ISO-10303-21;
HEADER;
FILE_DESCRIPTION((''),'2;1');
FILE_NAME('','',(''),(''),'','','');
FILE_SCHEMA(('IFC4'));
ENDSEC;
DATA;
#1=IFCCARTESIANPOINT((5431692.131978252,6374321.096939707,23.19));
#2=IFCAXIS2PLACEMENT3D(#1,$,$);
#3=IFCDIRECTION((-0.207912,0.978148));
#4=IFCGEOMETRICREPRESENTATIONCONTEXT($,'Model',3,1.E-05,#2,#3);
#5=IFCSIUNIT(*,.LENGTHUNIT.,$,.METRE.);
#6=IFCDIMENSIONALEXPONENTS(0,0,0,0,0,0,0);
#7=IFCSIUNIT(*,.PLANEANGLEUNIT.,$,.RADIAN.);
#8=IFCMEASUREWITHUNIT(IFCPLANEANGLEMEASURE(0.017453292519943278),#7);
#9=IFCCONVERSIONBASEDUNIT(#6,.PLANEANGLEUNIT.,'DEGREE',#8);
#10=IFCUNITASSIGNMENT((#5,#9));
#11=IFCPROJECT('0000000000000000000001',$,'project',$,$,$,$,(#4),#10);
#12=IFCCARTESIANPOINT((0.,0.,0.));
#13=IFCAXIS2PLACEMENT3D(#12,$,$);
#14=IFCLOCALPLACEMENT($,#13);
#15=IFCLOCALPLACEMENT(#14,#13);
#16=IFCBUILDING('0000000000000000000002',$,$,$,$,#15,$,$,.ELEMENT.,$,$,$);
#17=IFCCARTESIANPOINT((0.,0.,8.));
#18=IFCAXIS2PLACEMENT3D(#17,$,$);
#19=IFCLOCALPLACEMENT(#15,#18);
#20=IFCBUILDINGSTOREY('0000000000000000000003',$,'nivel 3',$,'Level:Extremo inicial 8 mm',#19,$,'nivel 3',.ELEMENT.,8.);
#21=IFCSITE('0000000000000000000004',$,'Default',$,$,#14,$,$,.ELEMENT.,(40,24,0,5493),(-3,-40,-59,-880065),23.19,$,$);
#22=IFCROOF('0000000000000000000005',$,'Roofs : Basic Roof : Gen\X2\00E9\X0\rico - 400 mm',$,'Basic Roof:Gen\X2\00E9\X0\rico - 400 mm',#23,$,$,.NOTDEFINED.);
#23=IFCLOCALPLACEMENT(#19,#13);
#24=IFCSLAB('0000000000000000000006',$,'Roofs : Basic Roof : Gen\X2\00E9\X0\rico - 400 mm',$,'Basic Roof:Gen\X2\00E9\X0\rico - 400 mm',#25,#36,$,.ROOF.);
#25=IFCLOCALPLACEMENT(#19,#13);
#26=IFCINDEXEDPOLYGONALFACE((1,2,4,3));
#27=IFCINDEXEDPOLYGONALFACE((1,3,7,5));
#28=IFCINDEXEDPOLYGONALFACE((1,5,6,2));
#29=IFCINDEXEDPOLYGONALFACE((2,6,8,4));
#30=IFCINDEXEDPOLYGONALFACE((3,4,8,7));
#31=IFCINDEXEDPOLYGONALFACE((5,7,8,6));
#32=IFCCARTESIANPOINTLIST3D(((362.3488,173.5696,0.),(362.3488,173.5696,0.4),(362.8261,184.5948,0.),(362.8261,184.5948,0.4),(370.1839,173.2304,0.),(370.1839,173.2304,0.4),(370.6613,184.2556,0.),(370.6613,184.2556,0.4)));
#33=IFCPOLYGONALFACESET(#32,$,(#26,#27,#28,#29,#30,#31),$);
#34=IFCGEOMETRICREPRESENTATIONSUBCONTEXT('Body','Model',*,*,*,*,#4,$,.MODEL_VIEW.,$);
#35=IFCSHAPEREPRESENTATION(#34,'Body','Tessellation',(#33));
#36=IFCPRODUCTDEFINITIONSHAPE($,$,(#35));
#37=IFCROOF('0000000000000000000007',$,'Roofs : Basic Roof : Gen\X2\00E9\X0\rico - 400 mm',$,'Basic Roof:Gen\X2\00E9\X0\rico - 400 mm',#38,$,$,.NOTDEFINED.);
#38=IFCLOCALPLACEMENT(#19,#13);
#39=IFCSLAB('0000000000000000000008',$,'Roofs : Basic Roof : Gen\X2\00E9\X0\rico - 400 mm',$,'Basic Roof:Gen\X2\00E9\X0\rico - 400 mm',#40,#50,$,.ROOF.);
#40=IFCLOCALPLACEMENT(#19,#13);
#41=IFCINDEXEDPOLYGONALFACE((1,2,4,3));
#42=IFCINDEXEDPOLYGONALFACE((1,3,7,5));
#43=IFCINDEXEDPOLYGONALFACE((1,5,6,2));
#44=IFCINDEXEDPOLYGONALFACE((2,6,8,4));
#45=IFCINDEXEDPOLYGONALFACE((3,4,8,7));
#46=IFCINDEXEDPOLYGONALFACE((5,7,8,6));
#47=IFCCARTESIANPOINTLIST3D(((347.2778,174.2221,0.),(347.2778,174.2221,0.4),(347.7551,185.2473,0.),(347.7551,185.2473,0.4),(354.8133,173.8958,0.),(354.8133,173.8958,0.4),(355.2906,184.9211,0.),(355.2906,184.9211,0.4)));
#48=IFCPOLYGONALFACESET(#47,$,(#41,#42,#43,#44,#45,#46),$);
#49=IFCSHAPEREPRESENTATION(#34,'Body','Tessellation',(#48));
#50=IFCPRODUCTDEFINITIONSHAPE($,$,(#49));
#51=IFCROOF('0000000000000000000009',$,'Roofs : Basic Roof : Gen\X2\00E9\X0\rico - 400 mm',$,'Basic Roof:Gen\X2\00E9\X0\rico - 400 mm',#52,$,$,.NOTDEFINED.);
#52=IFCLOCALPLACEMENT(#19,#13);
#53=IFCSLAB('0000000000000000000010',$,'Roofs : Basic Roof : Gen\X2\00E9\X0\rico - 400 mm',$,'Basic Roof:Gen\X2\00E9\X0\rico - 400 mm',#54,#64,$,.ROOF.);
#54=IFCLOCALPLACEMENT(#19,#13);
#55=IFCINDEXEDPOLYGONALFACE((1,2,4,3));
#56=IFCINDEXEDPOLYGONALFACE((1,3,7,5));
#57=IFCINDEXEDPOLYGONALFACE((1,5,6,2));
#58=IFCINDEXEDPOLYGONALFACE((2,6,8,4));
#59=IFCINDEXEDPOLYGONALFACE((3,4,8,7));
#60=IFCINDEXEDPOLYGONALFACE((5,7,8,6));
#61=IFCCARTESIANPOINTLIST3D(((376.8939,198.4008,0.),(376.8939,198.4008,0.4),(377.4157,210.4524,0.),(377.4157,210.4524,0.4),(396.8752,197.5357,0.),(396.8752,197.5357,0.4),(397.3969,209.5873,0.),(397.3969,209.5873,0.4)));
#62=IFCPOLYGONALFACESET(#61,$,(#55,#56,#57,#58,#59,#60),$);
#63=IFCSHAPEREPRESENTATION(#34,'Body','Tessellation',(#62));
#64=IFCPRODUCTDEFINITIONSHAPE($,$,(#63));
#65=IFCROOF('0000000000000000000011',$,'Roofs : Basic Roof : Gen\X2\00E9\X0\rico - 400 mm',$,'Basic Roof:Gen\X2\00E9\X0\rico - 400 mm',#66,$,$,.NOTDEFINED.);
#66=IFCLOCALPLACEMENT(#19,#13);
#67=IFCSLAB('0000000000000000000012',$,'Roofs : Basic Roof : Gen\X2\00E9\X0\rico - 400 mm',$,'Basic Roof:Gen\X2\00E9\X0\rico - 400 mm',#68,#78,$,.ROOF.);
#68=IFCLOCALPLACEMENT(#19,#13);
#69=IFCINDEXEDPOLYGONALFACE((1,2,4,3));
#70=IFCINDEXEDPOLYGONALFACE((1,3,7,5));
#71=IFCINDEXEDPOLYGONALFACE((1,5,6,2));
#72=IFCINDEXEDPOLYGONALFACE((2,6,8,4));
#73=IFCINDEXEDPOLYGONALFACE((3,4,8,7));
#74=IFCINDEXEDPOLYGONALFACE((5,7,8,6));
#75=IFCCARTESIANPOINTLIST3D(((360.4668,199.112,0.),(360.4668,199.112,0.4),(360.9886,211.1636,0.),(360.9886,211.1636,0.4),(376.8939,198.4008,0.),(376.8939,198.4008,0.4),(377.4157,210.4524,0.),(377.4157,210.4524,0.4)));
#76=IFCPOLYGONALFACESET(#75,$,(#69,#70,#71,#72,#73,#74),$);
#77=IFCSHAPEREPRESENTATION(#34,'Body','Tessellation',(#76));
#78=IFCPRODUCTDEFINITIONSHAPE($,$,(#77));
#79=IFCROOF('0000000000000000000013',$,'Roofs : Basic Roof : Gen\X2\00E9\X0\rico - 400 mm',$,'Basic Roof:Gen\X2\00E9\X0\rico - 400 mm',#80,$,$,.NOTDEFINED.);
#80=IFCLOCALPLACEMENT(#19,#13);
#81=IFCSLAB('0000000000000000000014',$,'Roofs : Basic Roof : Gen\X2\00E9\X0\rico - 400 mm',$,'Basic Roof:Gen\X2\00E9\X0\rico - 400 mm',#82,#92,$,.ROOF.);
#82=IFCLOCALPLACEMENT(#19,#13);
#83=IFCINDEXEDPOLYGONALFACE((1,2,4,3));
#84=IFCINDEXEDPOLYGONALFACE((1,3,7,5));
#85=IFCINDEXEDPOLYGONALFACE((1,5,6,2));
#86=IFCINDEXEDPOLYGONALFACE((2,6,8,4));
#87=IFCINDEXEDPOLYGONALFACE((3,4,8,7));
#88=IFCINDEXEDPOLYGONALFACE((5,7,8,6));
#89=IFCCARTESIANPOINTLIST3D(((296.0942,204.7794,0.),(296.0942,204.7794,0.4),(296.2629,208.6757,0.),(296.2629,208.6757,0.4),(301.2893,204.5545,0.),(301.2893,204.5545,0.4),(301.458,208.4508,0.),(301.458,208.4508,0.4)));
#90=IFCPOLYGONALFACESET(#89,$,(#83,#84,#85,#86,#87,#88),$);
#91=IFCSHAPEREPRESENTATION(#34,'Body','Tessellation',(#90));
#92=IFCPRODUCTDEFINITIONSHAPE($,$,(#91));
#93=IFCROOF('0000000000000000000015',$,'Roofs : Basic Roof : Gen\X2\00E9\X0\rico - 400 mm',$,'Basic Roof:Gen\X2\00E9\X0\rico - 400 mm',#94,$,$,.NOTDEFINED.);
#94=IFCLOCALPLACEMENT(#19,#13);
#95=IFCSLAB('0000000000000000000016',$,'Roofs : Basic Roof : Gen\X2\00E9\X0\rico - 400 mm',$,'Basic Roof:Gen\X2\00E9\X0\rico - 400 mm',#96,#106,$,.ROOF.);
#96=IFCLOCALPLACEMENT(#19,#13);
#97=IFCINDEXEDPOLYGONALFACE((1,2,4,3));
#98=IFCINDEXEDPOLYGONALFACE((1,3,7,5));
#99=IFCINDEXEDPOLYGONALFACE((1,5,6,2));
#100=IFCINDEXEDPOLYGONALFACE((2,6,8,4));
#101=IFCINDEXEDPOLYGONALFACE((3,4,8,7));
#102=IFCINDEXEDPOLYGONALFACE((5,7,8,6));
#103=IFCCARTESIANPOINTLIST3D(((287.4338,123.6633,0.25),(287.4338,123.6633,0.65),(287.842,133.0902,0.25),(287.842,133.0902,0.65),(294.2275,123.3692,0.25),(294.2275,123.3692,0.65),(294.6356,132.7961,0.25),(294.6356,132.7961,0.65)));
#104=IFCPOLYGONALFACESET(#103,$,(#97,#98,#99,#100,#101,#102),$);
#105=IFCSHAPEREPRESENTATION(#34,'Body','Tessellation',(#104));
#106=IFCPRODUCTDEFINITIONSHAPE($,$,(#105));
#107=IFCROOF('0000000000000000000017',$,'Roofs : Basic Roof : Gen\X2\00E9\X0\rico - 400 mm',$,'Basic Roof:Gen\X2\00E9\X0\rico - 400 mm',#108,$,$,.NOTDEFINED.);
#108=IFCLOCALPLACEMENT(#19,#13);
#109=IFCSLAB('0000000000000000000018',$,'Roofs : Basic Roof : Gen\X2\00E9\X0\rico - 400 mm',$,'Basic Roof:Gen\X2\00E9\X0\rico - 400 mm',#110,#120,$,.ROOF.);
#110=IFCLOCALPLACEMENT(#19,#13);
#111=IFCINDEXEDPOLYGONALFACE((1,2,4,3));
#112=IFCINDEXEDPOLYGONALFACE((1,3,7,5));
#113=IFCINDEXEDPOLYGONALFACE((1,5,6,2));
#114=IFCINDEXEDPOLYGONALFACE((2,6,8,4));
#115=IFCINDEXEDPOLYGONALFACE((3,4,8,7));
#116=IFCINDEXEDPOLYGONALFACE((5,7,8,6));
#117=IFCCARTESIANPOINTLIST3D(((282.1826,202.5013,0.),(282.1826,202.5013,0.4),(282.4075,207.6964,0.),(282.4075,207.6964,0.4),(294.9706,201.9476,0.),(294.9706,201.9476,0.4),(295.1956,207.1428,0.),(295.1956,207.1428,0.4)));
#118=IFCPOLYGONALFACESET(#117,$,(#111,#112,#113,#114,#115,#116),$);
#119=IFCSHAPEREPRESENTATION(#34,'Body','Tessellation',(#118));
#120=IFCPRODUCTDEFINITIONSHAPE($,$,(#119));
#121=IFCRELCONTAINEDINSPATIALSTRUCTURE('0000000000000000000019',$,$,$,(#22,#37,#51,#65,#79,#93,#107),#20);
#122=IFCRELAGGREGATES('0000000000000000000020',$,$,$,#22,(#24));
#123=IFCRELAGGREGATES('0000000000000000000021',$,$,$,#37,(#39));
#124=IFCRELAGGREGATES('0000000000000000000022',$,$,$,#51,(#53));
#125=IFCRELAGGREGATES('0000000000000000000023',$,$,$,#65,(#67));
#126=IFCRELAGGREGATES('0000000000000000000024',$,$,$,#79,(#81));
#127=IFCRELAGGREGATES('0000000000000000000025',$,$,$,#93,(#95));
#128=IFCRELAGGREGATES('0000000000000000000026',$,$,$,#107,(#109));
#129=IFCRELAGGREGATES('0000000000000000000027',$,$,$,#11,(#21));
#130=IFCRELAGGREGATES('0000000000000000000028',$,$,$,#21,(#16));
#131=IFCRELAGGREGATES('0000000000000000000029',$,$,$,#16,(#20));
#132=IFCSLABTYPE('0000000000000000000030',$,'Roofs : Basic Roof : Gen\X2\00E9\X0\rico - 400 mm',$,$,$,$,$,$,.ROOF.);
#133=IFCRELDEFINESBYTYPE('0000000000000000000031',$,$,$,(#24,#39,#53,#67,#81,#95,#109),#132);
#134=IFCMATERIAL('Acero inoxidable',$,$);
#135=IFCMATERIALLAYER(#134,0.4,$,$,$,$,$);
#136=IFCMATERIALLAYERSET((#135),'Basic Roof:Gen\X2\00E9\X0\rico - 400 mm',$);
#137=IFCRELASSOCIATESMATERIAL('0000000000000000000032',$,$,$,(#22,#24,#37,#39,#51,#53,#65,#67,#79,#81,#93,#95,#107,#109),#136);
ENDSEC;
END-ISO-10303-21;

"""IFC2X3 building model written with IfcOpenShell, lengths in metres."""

from ifc_helpers import new_model, entity, si_unit, converted_unit, direction, frame, frame_2d, origin, place, context, subcontext, project, spatial, rectangle, extrude, material, layer, layer_set, type_object, element, aggregate, save


model = new_model("IFC2X3")

# Units and contexts
model_context = context("Model", 3, precision=1e-05, world=frame((5431692.131978252, 6374321.096939707, 23.19)), true_north=direction((-0.207912, 0.978148)))
body_context = subcontext(model_context, "Body", "Model", "MODEL_VIEW")
ifc_project = project(units=[si_unit("LENGTHUNIT", "METRE"), converted_unit("PLANEANGLEUNIT", "DEGREE", entity("IfcPlaneAngleMeasure", 0.017453292519943278), si_unit("PLANEANGLEUNIT", "RADIAN"), dimensions=[0, 0, 0, 0, 0, 0, 0])], contexts=[model_context])

# Site, building, storey
site_placement = place(None, origin())
site = spatial("IfcSite", under=ifc_project, at=site_placement, Name="Default", CompositionType="ELEMENT", RefLatitude=(40, 24, 0, 5493), RefLongitude=(-3, -40, -59, -880065), RefElevation=23.19)
building_placement = place(site_placement, origin())
building = spatial("IfcBuilding", under=site, at=building_placement, CompositionType="ELEMENT")
storey_placement = place(building_placement, frame((0.0, 0.0, 8.0)))
storey = spatial("IfcBuildingStorey", under=building, at=storey_placement, Name="nivel 3", ObjectType="Level:Extremo inicial 8 mm", LongName="nivel 3", CompositionType="ELEMENT", Elevation=8.0)

# Shared definitions
ifc_material_1 = material(Name="Acero inoxidable")
ifc_layer = layer(ifc_material_1, 0.4)
ifc_layer_set = layer_set([ifc_layer], Name="Basic Roof:Genérico - 400 mm")
slab_type = type_object("IfcSlabType", Name="Roofs : Basic Roof : Genérico - 400 mm", PredefinedType="ROOF")

# Roofs, slabs
roof_1_placement = place(storey_placement, frame((362.3488, 173.2304, 0.0)))
roof_1 = element("IfcRoof", 1, at=roof_1_placement, inside=storey, material=ifc_layer_set, Name="Roofs : Basic Roof : Genérico - 400 mm", ObjectType="Basic Roof:Genérico - 400 mm", ShapeType="NOTDEFINED")
slab_1_placement = place(roof_1_placement, origin())
slab_1 = element("IfcSlab", 2, at=slab_1_placement, type_object=slab_type, material=ifc_layer_set, Name="Roofs : Basic Roof : Genérico - 400 mm", ObjectType="Basic Roof:Genérico - 400 mm", PredefinedType="ROOF", context=body_context, shape_type="SweptSolid", body=[
    extrude(rectangle(XDim=11.0356, YDim=7.8425, at=frame_2d((0.0, 0.0), x_axis=(0.043255, 0.999064))), frame((4.1563, 5.6822, 0.0)), (0.0, 0.0, 1.0), 0.4),
])
aggregate(roof_1, [slab_1])
roof_2_placement = place(storey_placement, frame((347.2778, 173.8958, 0.0)))
roof_2 = element("IfcRoof", 3, at=roof_2_placement, inside=storey, material=ifc_layer_set, Name="Roofs : Basic Roof : Genérico - 400 mm", ObjectType="Basic Roof:Genérico - 400 mm", ShapeType="NOTDEFINED")
slab_2_placement = place(roof_2_placement, origin())
slab_2 = element("IfcSlab", 4, at=slab_2_placement, type_object=slab_type, material=ifc_layer_set, Name="Roofs : Basic Roof : Genérico - 400 mm", ObjectType="Basic Roof:Genérico - 400 mm", PredefinedType="ROOF", context=body_context, shape_type="SweptSolid", body=[
    extrude(rectangle(XDim=11.0356, YDim=7.5425, at=frame_2d((0.0, 0.0), x_axis=(0.043255, 0.999064))), frame((4.0064, 5.6758, 0.0)), (0.0, 0.0, 1.0), 0.4),
])
aggregate(roof_2, [slab_2])
roof_3_placement = place(storey_placement, frame((376.8939, 197.5357, 0.0)))
roof_3 = element("IfcRoof", 5, at=roof_3_placement, inside=storey, material=ifc_layer_set, Name="Roofs : Basic Roof : Genérico - 400 mm", ObjectType="Basic Roof:Genérico - 400 mm", ShapeType="NOTDEFINED")
slab_3_placement = place(roof_3_placement, origin())
slab_3 = element("IfcSlab", 6, at=slab_3_placement, type_object=slab_type, material=ifc_layer_set, Name="Roofs : Basic Roof : Genérico - 400 mm", ObjectType="Basic Roof:Genérico - 400 mm", PredefinedType="ROOF", context=body_context, shape_type="SweptSolid", body=[
    extrude(rectangle(XDim=12.0629, YDim=20.0, at=frame_2d((0.0, 0.0), x_axis=(0.043255, 0.999064))), frame((10.2515, 6.4584, 0.0)), (0.0, 0.0, 1.0), 0.4),
])
aggregate(roof_3, [slab_3])
roof_4_placement = place(storey_placement, frame((360.4668, 198.4008, 0.0)))
roof_4 = element("IfcRoof", 7, at=roof_4_placement, inside=storey, material=ifc_layer_set, Name="Roofs : Basic Roof : Genérico - 400 mm", ObjectType="Basic Roof:Genérico - 400 mm", ShapeType="NOTDEFINED")
slab_4_placement = place(roof_4_placement, origin())
slab_4 = element("IfcSlab", 8, at=slab_4_placement, type_object=slab_type, material=ifc_layer_set, Name="Roofs : Basic Roof : Genérico - 400 mm", ObjectType="Basic Roof:Genérico - 400 mm", PredefinedType="ROOF", context=body_context, shape_type="SweptSolid", body=[
    extrude(rectangle(XDim=12.0629, YDim=16.4425, at=frame_2d((0.0, 0.0), x_axis=(0.043255, 0.999064))), frame((8.4744, 6.3814, 0.0)), (0.0, 0.0, 1.0), 0.4),
])
aggregate(roof_4, [slab_4])
roof_5_placement = place(storey_placement, frame((296.0942, 204.5545, 0.0)))
roof_5 = element("IfcRoof", 9, at=roof_5_placement, inside=storey, material=ifc_layer_set, Name="Roofs : Basic Roof : Genérico - 400 mm", ObjectType="Basic Roof:Genérico - 400 mm", ShapeType="NOTDEFINED")
slab_5_placement = place(roof_5_placement, origin())
slab_5 = element("IfcSlab", 10, at=slab_5_placement, type_object=slab_type, material=ifc_layer_set, Name="Roofs : Basic Roof : Genérico - 400 mm", ObjectType="Basic Roof:Genérico - 400 mm", PredefinedType="ROOF", context=body_context, shape_type="SweptSolid", body=[
    extrude(rectangle(XDim=3.9, YDim=5.2, at=frame_2d((0.0, 0.0), x_axis=(-0.043255, -0.999064))), frame((2.6819, 2.0606, 0.0)), (0.0, 0.0, 1.0), 0.4),
])
aggregate(roof_5, [slab_5])
roof_6_placement = place(storey_placement, frame((287.4338, 123.3692, 0.25)))
roof_6 = element("IfcRoof", 11, at=roof_6_placement, inside=storey, material=ifc_layer_set, Name="Roofs : Basic Roof : Genérico - 400 mm", ObjectType="Basic Roof:Genérico - 400 mm", ShapeType="NOTDEFINED")
slab_6_placement = place(roof_6_placement, origin())
slab_6 = element("IfcSlab", 12, at=slab_6_placement, type_object=slab_type, material=ifc_layer_set, Name="Roofs : Basic Roof : Genérico - 400 mm", ObjectType="Basic Roof:Genérico - 400 mm", PredefinedType="ROOF", context=body_context, shape_type="SweptSolid", body=[
    extrude(rectangle(XDim=6.8, YDim=9.4358, at=frame_2d((0.0, 0.0), x_axis=(-0.999064, 0.043255))), frame((3.6009, 4.8605, 0.0)), (0.0, 0.0, 1.0), 0.4),
])
aggregate(roof_6, [slab_6])
roof_7_placement = place(storey_placement, frame((282.1826, 201.9476, 0.0)))
roof_7 = element("IfcRoof", 13, at=roof_7_placement, inside=storey, material=ifc_layer_set, Name="Roofs : Basic Roof : Genérico - 400 mm", ObjectType="Basic Roof:Genérico - 400 mm", ShapeType="NOTDEFINED")
slab_7_placement = place(roof_7_placement, origin())
slab_7 = element("IfcSlab", 14, at=slab_7_placement, type_object=slab_type, material=ifc_layer_set, Name="Roofs : Basic Roof : Genérico - 400 mm", ObjectType="Basic Roof:Genérico - 400 mm", PredefinedType="ROOF", context=body_context, shape_type="SweptSolid", body=[
    extrude(rectangle(XDim=12.8, YDim=5.2, at=frame_2d((0.0, 0.0), x_axis=(0.999064, -0.043255))), frame((6.5065, 2.8744, 0.0)), (0.0, 0.0, 1.0), 0.4),
])
aggregate(roof_7, [slab_7])

save(model, "model.ifc")
